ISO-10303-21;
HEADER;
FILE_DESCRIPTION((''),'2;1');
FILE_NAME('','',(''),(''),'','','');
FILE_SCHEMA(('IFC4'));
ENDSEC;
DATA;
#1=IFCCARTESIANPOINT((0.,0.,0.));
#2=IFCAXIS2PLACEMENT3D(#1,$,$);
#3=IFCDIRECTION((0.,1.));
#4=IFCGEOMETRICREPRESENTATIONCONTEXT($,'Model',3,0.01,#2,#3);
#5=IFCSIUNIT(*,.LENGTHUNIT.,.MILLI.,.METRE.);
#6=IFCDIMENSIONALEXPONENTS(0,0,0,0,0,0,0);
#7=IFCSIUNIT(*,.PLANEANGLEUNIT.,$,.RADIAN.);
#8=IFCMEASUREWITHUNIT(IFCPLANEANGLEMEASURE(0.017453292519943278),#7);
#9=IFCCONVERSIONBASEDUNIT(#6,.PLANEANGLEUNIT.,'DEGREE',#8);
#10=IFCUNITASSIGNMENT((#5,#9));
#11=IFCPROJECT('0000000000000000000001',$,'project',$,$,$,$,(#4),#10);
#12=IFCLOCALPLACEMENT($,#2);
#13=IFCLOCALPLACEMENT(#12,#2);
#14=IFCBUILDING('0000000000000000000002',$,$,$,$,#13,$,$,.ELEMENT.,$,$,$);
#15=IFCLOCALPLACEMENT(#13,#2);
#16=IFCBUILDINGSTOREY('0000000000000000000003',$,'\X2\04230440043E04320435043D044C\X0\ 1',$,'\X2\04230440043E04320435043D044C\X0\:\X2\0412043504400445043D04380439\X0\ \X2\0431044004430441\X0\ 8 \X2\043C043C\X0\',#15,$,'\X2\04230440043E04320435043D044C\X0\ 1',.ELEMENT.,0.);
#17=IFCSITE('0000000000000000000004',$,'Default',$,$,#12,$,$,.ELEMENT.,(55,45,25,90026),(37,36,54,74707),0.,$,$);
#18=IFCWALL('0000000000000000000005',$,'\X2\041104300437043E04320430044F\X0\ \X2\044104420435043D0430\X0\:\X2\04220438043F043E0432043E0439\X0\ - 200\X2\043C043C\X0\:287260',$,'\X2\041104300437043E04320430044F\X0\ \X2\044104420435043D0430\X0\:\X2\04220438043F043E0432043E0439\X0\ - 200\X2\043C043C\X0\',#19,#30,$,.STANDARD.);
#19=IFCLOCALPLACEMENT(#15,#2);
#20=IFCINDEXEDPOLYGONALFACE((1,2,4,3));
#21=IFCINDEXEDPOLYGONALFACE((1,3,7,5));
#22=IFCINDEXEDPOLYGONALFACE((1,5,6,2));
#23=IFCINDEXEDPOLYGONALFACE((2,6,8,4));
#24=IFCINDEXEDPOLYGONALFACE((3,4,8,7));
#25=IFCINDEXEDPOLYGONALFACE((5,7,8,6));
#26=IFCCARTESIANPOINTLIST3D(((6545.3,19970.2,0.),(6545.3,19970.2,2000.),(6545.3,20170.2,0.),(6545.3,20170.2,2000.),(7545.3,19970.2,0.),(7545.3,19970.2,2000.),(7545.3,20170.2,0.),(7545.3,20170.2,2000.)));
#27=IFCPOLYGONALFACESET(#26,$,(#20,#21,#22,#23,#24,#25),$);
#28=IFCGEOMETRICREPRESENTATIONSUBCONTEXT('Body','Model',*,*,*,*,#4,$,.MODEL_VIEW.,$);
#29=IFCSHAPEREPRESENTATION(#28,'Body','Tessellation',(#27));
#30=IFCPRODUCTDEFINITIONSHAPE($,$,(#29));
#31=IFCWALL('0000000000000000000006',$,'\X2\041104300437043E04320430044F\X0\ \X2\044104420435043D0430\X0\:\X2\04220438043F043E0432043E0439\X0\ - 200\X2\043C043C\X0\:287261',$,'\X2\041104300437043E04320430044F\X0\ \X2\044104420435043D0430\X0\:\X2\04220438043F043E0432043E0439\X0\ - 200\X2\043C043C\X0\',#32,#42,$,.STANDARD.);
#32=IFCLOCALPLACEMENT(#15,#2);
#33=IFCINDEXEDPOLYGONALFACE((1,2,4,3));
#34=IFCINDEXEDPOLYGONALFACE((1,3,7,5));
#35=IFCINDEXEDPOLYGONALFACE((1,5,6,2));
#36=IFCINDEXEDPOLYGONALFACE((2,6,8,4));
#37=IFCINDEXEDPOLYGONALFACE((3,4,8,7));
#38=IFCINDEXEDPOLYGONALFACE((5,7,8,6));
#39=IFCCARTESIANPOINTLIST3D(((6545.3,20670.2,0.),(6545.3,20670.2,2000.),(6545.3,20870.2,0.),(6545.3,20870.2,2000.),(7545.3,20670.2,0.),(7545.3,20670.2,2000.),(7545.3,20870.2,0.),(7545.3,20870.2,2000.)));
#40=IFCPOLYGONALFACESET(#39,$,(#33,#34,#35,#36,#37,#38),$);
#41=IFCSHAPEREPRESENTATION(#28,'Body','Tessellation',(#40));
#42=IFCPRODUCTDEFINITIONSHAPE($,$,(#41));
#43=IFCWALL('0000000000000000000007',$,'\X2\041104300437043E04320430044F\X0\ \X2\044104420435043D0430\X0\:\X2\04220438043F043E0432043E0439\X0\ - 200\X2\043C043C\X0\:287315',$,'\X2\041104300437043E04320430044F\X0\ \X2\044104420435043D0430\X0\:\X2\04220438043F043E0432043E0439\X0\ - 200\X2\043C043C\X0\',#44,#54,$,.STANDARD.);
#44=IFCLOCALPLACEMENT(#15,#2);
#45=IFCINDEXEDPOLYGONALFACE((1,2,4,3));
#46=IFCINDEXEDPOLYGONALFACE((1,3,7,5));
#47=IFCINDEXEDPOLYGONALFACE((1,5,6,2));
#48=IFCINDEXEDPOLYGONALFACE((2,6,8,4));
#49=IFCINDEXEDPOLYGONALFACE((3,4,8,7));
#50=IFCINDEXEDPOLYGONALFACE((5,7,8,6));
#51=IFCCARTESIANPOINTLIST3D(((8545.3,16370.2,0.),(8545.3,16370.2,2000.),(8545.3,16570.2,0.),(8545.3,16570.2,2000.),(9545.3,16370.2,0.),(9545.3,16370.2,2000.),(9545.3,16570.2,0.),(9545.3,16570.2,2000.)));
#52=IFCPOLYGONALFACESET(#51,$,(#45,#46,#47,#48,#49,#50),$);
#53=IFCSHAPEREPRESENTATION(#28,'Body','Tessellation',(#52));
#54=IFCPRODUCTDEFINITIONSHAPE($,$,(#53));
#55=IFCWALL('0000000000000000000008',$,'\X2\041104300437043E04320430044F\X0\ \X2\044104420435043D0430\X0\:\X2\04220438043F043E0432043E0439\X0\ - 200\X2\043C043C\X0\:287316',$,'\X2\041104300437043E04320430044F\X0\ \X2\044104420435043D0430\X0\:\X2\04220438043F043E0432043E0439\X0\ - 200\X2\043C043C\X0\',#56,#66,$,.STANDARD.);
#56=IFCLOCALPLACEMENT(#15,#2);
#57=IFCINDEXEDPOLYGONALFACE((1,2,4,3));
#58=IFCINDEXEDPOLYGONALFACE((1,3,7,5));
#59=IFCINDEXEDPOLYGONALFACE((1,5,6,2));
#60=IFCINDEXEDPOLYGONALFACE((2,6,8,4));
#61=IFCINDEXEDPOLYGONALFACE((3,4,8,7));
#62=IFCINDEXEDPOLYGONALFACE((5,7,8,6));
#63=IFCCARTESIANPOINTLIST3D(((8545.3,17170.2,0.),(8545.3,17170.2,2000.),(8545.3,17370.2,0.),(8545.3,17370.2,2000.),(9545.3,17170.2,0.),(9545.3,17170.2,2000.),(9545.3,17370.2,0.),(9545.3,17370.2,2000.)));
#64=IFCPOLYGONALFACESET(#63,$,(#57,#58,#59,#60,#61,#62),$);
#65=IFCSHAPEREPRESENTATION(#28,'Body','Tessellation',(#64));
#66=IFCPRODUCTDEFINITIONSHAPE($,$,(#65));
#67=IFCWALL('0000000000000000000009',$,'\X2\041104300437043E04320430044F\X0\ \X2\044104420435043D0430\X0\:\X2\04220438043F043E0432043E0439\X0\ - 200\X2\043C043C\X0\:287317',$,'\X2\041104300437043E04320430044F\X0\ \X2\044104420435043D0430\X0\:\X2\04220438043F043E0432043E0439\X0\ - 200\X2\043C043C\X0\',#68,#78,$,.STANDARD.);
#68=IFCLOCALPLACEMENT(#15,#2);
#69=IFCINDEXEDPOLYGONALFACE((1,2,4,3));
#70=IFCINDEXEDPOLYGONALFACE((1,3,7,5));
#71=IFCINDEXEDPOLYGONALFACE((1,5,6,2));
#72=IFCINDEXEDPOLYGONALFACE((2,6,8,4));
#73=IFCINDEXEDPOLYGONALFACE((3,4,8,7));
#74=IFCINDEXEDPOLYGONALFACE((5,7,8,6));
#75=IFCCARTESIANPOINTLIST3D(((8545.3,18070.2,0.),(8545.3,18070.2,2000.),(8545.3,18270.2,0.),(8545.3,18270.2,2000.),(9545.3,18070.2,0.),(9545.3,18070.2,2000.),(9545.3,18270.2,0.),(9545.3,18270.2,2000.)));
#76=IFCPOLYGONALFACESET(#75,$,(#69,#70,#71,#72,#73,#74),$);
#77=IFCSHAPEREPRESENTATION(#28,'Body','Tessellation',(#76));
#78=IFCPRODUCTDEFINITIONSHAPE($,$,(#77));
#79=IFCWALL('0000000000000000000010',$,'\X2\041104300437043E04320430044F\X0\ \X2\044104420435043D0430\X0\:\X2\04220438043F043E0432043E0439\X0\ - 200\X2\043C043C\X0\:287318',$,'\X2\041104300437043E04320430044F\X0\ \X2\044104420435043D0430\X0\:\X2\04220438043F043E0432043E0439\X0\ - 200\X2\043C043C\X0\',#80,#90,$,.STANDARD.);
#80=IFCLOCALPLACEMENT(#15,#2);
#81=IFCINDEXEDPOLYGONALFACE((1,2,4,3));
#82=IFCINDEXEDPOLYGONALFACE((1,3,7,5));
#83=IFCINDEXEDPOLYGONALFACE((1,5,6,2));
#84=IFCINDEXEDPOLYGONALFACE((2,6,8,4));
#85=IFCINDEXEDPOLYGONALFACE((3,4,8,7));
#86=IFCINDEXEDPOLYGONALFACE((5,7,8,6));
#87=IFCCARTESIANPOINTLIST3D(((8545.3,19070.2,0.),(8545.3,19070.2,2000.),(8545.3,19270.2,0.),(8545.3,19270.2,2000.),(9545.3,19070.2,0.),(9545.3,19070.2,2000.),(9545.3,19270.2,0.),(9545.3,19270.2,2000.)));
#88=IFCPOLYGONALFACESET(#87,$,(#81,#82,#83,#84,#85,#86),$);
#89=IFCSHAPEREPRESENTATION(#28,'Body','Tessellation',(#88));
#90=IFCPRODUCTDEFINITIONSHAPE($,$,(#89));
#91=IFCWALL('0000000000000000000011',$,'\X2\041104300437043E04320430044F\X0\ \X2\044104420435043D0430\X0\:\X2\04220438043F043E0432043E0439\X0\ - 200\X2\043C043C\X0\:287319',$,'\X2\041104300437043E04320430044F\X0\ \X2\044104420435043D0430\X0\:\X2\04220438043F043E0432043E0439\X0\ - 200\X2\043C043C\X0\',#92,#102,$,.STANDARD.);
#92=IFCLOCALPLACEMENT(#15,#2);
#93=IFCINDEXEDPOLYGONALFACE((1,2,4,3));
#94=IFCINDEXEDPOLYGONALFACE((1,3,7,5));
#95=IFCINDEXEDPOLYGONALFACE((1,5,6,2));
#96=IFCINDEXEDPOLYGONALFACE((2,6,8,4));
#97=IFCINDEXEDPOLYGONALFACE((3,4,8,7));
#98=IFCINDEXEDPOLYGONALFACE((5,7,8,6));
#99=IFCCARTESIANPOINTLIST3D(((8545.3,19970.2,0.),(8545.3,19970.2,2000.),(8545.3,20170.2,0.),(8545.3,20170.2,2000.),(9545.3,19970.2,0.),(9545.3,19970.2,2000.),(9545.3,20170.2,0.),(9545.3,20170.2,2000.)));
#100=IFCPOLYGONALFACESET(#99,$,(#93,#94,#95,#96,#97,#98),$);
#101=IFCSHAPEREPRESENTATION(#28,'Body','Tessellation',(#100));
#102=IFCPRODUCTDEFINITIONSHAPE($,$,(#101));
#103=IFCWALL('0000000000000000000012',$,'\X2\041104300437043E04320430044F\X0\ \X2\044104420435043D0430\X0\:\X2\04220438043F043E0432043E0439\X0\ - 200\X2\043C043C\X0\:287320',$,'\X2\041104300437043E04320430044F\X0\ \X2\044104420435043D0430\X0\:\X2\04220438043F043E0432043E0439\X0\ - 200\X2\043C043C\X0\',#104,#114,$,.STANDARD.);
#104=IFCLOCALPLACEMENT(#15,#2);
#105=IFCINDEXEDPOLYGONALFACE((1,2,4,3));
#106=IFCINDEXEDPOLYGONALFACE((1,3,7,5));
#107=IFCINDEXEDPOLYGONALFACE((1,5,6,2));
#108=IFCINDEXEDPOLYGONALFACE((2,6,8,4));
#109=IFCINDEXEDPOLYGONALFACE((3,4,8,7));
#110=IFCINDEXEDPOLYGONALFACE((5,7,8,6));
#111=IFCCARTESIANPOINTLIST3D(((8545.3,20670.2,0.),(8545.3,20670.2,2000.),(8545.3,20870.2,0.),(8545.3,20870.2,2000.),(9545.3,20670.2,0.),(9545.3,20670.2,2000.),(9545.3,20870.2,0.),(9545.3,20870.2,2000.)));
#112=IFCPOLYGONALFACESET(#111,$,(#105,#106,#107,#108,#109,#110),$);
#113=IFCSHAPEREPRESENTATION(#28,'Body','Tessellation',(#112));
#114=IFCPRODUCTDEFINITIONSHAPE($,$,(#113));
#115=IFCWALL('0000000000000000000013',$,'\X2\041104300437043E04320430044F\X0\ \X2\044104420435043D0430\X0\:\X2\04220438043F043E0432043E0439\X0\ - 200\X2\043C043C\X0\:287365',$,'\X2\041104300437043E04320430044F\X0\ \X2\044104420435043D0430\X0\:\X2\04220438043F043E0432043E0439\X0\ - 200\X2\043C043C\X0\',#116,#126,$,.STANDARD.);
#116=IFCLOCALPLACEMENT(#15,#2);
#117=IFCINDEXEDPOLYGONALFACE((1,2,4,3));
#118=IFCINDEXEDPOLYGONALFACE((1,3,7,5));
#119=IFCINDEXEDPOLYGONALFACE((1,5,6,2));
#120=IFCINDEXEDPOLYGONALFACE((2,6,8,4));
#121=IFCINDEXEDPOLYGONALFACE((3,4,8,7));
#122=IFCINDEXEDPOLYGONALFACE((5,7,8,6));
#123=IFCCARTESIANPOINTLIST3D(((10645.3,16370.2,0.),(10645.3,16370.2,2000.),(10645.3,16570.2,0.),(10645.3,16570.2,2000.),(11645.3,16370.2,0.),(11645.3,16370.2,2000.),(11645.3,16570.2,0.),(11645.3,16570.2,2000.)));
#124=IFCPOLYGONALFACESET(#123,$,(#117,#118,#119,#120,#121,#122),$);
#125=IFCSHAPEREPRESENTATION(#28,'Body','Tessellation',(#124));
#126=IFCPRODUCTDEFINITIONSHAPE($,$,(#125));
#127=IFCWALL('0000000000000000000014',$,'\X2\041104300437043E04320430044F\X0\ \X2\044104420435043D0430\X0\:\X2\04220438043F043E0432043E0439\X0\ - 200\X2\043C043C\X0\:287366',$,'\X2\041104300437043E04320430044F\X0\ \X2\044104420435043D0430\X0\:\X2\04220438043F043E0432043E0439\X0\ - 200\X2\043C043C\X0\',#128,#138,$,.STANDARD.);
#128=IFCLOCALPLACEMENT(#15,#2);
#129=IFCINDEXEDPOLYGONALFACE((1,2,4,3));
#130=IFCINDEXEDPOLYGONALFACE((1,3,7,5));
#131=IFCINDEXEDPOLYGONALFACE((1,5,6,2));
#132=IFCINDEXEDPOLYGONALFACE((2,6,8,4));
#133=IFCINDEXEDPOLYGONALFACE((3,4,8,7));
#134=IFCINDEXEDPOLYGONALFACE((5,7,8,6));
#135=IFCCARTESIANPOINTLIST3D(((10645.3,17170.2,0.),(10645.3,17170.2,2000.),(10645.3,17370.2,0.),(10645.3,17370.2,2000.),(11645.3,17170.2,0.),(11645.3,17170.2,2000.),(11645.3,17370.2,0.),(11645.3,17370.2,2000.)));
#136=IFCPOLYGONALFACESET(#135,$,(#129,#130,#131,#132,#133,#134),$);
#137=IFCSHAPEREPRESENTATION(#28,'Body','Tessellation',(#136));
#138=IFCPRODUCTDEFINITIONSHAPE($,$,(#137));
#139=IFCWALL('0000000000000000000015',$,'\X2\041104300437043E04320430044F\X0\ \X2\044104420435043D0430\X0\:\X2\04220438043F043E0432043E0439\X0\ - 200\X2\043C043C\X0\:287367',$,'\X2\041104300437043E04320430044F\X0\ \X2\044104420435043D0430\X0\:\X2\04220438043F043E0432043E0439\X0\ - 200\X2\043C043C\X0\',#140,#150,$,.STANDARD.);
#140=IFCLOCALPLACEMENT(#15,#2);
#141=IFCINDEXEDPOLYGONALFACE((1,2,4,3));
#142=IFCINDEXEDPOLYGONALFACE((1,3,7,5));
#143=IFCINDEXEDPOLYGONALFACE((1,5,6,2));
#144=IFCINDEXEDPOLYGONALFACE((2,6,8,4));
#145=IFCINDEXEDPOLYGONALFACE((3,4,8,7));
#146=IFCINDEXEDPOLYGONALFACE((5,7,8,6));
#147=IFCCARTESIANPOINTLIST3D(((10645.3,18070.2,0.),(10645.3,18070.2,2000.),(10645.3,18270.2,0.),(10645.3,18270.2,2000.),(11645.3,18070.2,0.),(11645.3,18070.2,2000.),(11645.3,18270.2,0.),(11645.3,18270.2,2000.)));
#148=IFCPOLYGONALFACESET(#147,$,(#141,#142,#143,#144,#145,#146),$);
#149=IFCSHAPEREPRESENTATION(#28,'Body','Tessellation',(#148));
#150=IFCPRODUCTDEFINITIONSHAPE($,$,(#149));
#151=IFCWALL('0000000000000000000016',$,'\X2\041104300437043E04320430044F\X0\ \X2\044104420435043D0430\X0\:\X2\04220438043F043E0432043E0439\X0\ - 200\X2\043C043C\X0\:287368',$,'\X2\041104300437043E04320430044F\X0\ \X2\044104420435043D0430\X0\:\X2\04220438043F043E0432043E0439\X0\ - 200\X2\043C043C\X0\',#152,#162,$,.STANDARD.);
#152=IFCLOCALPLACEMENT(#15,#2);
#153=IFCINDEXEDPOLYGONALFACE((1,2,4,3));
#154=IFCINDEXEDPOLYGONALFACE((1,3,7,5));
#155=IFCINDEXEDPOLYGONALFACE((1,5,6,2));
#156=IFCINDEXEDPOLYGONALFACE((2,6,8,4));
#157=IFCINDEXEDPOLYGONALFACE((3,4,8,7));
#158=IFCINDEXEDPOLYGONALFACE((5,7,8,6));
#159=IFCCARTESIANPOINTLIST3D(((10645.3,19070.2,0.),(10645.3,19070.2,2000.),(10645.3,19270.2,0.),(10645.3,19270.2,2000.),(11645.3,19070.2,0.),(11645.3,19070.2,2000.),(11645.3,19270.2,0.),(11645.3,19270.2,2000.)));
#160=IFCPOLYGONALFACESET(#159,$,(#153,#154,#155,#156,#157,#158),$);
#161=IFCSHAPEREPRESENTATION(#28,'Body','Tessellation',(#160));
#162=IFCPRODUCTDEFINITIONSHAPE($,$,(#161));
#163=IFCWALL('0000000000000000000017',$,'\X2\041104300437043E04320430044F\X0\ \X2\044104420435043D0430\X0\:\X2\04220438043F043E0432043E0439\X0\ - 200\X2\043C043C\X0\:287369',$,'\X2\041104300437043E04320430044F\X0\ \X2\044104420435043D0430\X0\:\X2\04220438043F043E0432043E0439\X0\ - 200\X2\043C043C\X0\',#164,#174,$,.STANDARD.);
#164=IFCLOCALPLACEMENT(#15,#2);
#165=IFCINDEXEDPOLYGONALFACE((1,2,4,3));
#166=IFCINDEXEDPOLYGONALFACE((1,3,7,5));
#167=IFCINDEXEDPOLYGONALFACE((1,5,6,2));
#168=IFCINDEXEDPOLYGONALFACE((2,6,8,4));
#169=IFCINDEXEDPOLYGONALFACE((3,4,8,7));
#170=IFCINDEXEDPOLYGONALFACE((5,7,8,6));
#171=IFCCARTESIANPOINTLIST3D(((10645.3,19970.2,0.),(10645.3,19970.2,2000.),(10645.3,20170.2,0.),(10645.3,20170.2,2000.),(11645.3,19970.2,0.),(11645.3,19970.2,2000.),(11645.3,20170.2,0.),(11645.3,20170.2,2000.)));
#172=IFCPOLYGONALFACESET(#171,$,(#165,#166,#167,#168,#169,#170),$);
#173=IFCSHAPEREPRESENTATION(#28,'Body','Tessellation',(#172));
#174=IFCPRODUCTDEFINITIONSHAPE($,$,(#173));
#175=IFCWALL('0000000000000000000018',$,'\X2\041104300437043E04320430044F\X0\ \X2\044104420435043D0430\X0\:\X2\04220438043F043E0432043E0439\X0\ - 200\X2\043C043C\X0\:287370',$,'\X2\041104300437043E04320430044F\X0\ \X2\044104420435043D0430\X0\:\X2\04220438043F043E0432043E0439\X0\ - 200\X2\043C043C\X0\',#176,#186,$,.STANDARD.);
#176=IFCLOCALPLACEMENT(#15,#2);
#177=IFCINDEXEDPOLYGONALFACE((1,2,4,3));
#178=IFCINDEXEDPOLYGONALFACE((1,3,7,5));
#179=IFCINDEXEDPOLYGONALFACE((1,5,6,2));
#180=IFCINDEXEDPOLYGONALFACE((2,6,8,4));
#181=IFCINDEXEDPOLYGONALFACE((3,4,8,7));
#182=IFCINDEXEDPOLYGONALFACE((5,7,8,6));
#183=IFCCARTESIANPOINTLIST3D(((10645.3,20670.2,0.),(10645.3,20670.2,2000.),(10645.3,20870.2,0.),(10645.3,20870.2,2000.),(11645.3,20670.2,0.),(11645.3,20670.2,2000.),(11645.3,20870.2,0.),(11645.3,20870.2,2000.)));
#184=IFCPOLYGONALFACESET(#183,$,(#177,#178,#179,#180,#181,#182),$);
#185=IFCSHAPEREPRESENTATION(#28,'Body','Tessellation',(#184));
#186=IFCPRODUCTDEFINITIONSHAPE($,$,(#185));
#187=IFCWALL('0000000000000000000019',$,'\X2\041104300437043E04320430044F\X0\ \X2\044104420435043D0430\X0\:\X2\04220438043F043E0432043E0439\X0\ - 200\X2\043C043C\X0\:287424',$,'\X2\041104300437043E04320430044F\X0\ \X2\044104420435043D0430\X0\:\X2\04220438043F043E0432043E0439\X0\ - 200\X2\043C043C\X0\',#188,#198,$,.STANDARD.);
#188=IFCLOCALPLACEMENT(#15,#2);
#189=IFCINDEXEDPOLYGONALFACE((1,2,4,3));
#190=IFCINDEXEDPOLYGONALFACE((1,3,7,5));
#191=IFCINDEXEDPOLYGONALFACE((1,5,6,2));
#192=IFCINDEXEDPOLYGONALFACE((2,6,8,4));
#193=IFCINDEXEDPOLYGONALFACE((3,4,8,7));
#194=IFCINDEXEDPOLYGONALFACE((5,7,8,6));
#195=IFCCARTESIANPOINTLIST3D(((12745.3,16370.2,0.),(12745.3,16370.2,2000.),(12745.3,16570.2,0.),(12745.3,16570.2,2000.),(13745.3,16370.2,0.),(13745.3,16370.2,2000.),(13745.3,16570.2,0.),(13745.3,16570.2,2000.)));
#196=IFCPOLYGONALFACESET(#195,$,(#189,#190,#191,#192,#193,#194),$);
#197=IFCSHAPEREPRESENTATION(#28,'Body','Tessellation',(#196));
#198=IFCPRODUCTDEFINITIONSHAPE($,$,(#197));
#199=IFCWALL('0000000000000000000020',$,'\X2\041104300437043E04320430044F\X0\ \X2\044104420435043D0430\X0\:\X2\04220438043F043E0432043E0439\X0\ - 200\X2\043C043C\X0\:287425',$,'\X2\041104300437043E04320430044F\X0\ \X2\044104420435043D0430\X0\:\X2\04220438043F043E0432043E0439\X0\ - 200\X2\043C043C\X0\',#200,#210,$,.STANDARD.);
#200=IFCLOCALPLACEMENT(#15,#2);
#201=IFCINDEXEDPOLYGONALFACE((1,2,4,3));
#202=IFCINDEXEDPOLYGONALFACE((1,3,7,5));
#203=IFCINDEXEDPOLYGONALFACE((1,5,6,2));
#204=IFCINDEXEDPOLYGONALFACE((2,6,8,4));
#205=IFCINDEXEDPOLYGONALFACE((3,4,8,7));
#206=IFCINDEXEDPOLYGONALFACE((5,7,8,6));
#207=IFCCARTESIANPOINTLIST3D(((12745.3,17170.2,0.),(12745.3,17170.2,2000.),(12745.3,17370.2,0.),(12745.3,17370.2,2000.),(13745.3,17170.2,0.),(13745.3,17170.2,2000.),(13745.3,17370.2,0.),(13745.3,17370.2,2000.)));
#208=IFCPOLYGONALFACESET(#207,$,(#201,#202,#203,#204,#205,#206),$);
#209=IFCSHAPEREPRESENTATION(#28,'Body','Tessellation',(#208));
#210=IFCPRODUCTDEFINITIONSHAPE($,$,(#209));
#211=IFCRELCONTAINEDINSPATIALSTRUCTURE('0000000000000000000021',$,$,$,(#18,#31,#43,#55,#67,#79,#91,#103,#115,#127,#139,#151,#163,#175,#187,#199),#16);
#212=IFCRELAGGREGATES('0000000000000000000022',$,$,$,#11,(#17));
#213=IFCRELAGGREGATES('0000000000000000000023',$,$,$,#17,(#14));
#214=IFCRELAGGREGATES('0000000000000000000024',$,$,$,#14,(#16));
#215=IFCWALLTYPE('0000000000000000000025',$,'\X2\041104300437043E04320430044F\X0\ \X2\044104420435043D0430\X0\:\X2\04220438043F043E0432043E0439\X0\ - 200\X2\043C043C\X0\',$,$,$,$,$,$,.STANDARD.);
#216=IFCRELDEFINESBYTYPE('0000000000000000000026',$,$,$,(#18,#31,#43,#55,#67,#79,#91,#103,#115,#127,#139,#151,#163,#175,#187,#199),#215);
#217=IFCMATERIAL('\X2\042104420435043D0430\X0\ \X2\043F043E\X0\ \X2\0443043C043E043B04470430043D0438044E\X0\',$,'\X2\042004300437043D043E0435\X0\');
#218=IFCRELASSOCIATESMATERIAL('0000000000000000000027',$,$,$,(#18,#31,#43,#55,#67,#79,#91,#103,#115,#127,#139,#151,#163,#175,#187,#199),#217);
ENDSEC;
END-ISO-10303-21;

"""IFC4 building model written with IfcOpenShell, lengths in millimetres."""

from ifc_helpers import new_model, entity, si_unit, converted_unit, direction, frame, origin, place, context, subcontext, project, spatial, indexed_curve, outline, extrude, material, type_object, element, save


model = new_model("IFC4")

# Units and contexts
model_context = context("Model", 3, precision=0.01, world=origin(), true_north=direction((0.0, 1.0)))
body_context = subcontext(model_context, "Body", "Model", "MODEL_VIEW")
ifc_project = project(units=[si_unit("LENGTHUNIT", "METRE", prefix="MILLI"), converted_unit("PLANEANGLEUNIT", "DEGREE", entity("IfcPlaneAngleMeasure", 0.017453292519943278), si_unit("PLANEANGLEUNIT", "RADIAN"), dimensions=[0, 0, 0, 0, 0, 0, 0])], contexts=[model_context])

# Site, building, storey
site_placement = place(None, origin())
site = spatial("IfcSite", under=ifc_project, at=site_placement, Name="Default", CompositionType="ELEMENT", RefLatitude=(55, 45, 25, 90026), RefLongitude=(37, 36, 54, 74707), RefElevation=0.0)
building_placement = place(site_placement, origin())
building = spatial("IfcBuilding", under=site, at=building_placement, CompositionType="ELEMENT")
storey_placement = place(building_placement, origin())
storey = spatial("IfcBuildingStorey", under=building, at=storey_placement, Name="Уровень 1", ObjectType="Уровень:Верхний брус 8 мм", LongName="Уровень 1", CompositionType="ELEMENT", Elevation=0.0)

# Walls
ifc_material = material(Name="Стена по умолчанию", Category="Разное")
wall_type = type_object("IfcWallType", Name="Базовая стена:Типовой - 200мм", PredefinedType="STANDARD")
for number, where, name in (
    (1, (6545.3, 20070.2, 0.0), "Базовая стена:Типовой - 200мм:287260"),
    (2, (6545.3, 20770.2, 0.0), "Базовая стена:Типовой - 200мм:287261"),
):
    element("IfcWall", number, at=place(storey_placement, frame(where)), inside=storey, type_object=wall_type, material=ifc_material, Name=name, ObjectType="Базовая стена:Типовой - 200мм", PredefinedType="STANDARD", context=body_context, shape_type="SweptSolid", body=[
        extrude(outline(indexed_curve([(1000.0, 100.0), (0.0, 100.0), (0.0, -100.0), (1000.0, -100.0), (1000.0, 100.0)], self_intersect=False)), origin(), (0.0, 0.0, 1.0), 2000.0),
    ])
wall_1_placement = place(storey_placement, frame((8545.3, 16470.2, 0.0)))
element("IfcWall", 3, at=wall_1_placement, inside=storey, type_object=wall_type, material=ifc_material, Name="Базовая стена:Типовой - 200мм:287315", ObjectType="Базовая стена:Типовой - 200мм", PredefinedType="STANDARD", context=body_context, shape_type="SweptSolid", body=[
    extrude(outline(indexed_curve([(1000.0, 100.0), (0.0, 100.0), (0.0, -100.0), (1000.0, -100.0), (1000.0, 100.0)], self_intersect=False)), origin(), (0.0, 0.0, 1.0), 2000.0),
])
wall_2_placement = place(storey_placement, frame((8545.3, 17270.2, 0.0)))
element("IfcWall", 4, at=wall_2_placement, inside=storey, type_object=wall_type, material=ifc_material, Name="Базовая стена:Типовой - 200мм:287316", ObjectType="Базовая стена:Типовой - 200мм", PredefinedType="STANDARD", context=body_context, shape_type="SweptSolid", body=[
    extrude(outline(indexed_curve([(1000.0, 100.0), (0.0, 100.0), (0.0, -100.0), (1000.0, -100.0), (1000.0, 100.0)], self_intersect=False)), origin(), (0.0, 0.0, 1.0), 2000.0),
])
for number, where, name in (
    (5, (8545.3, 18170.2, 0.0), "Базовая стена:Типовой - 200мм:287317"),
    (6, (8545.3, 19170.2, 0.0), "Базовая стена:Типовой - 200мм:287318"),
):
    element("IfcWall", number, at=place(storey_placement, frame(where)), inside=storey, type_object=wall_type, material=ifc_material, Name=name, ObjectType="Базовая стена:Типовой - 200мм", PredefinedType="STANDARD", context=body_context, shape_type="SweptSolid", body=[
        extrude(outline(indexed_curve([(1000.0, 100.0), (0.0, 100.0), (0.0, -100.0), (1000.0, -100.0), (1000.0, 100.0)], self_intersect=False)), origin(), (0.0, 0.0, 1.0), 2000.0),
    ])
for number, where, name in (
    (7, (8545.3, 20070.2, 0.0), "Базовая стена:Типовой - 200мм:287319"),
    (8, (8545.3, 20770.2, 0.0), "Базовая стена:Типовой - 200мм:287320"),
):
    element("IfcWall", number, at=place(storey_placement, frame(where)), inside=storey, type_object=wall_type, material=ifc_material, Name=name, ObjectType="Базовая стена:Типовой - 200мм", PredefinedType="STANDARD", context=body_context, shape_type="SweptSolid", body=[
        extrude(outline(indexed_curve([(1000.0, 100.0), (0.0, 100.0), (0.0, -100.0), (1000.0, -100.0), (1000.0, 100.0)], self_intersect=False)), origin(), (0.0, 0.0, 1.0), 2000.0),
    ])
wall_3_placement = place(storey_placement, frame((10645.3, 16470.2, 0.0)))
element("IfcWall", 9, at=wall_3_placement, inside=storey, type_object=wall_type, material=ifc_material, Name="Базовая стена:Типовой - 200мм:287365", ObjectType="Базовая стена:Типовой - 200мм", PredefinedType="STANDARD", context=body_context, shape_type="SweptSolid", body=[
    extrude(outline(indexed_curve([(1000.0, 100.0), (0.0, 100.0), (0.0, -100.0), (1000.0, -100.0), (1000.0, 100.0)], self_intersect=False)), origin(), (0.0, 0.0, 1.0), 2000.0),
])
wall_4_placement = place(storey_placement, frame((10645.3, 17270.2, 0.0)))
element("IfcWall", 10, at=wall_4_placement, inside=storey, type_object=wall_type, material=ifc_material, Name="Базовая стена:Типовой - 200мм:287366", ObjectType="Базовая стена:Типовой - 200мм", PredefinedType="STANDARD", context=body_context, shape_type="SweptSolid", body=[
    extrude(outline(indexed_curve([(1000.0, 100.0), (0.0, 100.0), (0.0, -100.0), (1000.0, -100.0), (1000.0, 100.0)], self_intersect=False)), origin(), (0.0, 0.0, 1.0), 2000.0),
])
for number, where, name in (
    (11, (10645.3, 18170.2, 0.0), "Базовая стена:Типовой - 200мм:287367"),
    (12, (10645.3, 19170.2, 0.0), "Базовая стена:Типовой - 200мм:287368"),
):
    element("IfcWall", number, at=place(storey_placement, frame(where)), inside=storey, type_object=wall_type, material=ifc_material, Name=name, ObjectType="Базовая стена:Типовой - 200мм", PredefinedType="STANDARD", context=body_context, shape_type="SweptSolid", body=[
        extrude(outline(indexed_curve([(1000.0, 100.0), (0.0, 100.0), (0.0, -100.0), (1000.0, -100.0), (1000.0, 100.0)], self_intersect=False)), origin(), (0.0, 0.0, 1.0), 2000.0),
    ])
wall_5_placement = place(storey_placement, frame((10645.3, 20070.2, 0.0)))
element("IfcWall", 13, at=wall_5_placement, inside=storey, type_object=wall_type, material=ifc_material, Name="Базовая стена:Типовой - 200мм:287369", ObjectType="Базовая стена:Типовой - 200мм", PredefinedType="STANDARD", context=body_context, shape_type="SweptSolid", body=[
    extrude(outline(indexed_curve([(1000.0, 100.0), (0.0, 100.0), (0.0, -100.0), (1000.0, -100.0), (1000.0, 100.0)], self_intersect=False)), origin(), (0.0, 0.0, 1.0), 2000.0),
])
wall_6_placement = place(storey_placement, frame((10645.3, 20770.2, 0.0)))
element("IfcWall", 14, at=wall_6_placement, inside=storey, type_object=wall_type, material=ifc_material, Name="Базовая стена:Типовой - 200мм:287370", ObjectType="Базовая стена:Типовой - 200мм", PredefinedType="STANDARD", context=body_context, shape_type="SweptSolid", body=[
    extrude(outline(indexed_curve([(1000.0, 100.0), (0.0, 100.0), (0.0, -100.0), (1000.0, -100.0), (1000.0, 100.0)], self_intersect=False)), origin(), (0.0, 0.0, 1.0), 2000.0),
])
wall_7_placement = place(storey_placement, frame((12745.3, 16470.2, 0.0)))
element("IfcWall", 15, at=wall_7_placement, inside=storey, type_object=wall_type, material=ifc_material, Name="Базовая стена:Типовой - 200мм:287424", ObjectType="Базовая стена:Типовой - 200мм", PredefinedType="STANDARD", context=body_context, shape_type="SweptSolid", body=[
    extrude(outline(indexed_curve([(1000.0, 100.0), (0.0, 100.0), (0.0, -100.0), (1000.0, -100.0), (1000.0, 100.0)], self_intersect=False)), origin(), (0.0, 0.0, 1.0), 2000.0),
])
wall_8_placement = place(storey_placement, frame((12745.3, 17270.2, 0.0)))
element("IfcWall", 16, at=wall_8_placement, inside=storey, type_object=wall_type, material=ifc_material, Name="Базовая стена:Типовой - 200мм:287425", ObjectType="Базовая стена:Типовой - 200мм", PredefinedType="STANDARD", context=body_context, shape_type="SweptSolid", body=[
    extrude(outline(indexed_curve([(1000.0, 100.0), (0.0, 100.0), (0.0, -100.0), (1000.0, -100.0), (1000.0, 100.0)], self_intersect=False)), origin(), (0.0, 0.0, 1.0), 2000.0),
])

save(model, "model.ifc")
